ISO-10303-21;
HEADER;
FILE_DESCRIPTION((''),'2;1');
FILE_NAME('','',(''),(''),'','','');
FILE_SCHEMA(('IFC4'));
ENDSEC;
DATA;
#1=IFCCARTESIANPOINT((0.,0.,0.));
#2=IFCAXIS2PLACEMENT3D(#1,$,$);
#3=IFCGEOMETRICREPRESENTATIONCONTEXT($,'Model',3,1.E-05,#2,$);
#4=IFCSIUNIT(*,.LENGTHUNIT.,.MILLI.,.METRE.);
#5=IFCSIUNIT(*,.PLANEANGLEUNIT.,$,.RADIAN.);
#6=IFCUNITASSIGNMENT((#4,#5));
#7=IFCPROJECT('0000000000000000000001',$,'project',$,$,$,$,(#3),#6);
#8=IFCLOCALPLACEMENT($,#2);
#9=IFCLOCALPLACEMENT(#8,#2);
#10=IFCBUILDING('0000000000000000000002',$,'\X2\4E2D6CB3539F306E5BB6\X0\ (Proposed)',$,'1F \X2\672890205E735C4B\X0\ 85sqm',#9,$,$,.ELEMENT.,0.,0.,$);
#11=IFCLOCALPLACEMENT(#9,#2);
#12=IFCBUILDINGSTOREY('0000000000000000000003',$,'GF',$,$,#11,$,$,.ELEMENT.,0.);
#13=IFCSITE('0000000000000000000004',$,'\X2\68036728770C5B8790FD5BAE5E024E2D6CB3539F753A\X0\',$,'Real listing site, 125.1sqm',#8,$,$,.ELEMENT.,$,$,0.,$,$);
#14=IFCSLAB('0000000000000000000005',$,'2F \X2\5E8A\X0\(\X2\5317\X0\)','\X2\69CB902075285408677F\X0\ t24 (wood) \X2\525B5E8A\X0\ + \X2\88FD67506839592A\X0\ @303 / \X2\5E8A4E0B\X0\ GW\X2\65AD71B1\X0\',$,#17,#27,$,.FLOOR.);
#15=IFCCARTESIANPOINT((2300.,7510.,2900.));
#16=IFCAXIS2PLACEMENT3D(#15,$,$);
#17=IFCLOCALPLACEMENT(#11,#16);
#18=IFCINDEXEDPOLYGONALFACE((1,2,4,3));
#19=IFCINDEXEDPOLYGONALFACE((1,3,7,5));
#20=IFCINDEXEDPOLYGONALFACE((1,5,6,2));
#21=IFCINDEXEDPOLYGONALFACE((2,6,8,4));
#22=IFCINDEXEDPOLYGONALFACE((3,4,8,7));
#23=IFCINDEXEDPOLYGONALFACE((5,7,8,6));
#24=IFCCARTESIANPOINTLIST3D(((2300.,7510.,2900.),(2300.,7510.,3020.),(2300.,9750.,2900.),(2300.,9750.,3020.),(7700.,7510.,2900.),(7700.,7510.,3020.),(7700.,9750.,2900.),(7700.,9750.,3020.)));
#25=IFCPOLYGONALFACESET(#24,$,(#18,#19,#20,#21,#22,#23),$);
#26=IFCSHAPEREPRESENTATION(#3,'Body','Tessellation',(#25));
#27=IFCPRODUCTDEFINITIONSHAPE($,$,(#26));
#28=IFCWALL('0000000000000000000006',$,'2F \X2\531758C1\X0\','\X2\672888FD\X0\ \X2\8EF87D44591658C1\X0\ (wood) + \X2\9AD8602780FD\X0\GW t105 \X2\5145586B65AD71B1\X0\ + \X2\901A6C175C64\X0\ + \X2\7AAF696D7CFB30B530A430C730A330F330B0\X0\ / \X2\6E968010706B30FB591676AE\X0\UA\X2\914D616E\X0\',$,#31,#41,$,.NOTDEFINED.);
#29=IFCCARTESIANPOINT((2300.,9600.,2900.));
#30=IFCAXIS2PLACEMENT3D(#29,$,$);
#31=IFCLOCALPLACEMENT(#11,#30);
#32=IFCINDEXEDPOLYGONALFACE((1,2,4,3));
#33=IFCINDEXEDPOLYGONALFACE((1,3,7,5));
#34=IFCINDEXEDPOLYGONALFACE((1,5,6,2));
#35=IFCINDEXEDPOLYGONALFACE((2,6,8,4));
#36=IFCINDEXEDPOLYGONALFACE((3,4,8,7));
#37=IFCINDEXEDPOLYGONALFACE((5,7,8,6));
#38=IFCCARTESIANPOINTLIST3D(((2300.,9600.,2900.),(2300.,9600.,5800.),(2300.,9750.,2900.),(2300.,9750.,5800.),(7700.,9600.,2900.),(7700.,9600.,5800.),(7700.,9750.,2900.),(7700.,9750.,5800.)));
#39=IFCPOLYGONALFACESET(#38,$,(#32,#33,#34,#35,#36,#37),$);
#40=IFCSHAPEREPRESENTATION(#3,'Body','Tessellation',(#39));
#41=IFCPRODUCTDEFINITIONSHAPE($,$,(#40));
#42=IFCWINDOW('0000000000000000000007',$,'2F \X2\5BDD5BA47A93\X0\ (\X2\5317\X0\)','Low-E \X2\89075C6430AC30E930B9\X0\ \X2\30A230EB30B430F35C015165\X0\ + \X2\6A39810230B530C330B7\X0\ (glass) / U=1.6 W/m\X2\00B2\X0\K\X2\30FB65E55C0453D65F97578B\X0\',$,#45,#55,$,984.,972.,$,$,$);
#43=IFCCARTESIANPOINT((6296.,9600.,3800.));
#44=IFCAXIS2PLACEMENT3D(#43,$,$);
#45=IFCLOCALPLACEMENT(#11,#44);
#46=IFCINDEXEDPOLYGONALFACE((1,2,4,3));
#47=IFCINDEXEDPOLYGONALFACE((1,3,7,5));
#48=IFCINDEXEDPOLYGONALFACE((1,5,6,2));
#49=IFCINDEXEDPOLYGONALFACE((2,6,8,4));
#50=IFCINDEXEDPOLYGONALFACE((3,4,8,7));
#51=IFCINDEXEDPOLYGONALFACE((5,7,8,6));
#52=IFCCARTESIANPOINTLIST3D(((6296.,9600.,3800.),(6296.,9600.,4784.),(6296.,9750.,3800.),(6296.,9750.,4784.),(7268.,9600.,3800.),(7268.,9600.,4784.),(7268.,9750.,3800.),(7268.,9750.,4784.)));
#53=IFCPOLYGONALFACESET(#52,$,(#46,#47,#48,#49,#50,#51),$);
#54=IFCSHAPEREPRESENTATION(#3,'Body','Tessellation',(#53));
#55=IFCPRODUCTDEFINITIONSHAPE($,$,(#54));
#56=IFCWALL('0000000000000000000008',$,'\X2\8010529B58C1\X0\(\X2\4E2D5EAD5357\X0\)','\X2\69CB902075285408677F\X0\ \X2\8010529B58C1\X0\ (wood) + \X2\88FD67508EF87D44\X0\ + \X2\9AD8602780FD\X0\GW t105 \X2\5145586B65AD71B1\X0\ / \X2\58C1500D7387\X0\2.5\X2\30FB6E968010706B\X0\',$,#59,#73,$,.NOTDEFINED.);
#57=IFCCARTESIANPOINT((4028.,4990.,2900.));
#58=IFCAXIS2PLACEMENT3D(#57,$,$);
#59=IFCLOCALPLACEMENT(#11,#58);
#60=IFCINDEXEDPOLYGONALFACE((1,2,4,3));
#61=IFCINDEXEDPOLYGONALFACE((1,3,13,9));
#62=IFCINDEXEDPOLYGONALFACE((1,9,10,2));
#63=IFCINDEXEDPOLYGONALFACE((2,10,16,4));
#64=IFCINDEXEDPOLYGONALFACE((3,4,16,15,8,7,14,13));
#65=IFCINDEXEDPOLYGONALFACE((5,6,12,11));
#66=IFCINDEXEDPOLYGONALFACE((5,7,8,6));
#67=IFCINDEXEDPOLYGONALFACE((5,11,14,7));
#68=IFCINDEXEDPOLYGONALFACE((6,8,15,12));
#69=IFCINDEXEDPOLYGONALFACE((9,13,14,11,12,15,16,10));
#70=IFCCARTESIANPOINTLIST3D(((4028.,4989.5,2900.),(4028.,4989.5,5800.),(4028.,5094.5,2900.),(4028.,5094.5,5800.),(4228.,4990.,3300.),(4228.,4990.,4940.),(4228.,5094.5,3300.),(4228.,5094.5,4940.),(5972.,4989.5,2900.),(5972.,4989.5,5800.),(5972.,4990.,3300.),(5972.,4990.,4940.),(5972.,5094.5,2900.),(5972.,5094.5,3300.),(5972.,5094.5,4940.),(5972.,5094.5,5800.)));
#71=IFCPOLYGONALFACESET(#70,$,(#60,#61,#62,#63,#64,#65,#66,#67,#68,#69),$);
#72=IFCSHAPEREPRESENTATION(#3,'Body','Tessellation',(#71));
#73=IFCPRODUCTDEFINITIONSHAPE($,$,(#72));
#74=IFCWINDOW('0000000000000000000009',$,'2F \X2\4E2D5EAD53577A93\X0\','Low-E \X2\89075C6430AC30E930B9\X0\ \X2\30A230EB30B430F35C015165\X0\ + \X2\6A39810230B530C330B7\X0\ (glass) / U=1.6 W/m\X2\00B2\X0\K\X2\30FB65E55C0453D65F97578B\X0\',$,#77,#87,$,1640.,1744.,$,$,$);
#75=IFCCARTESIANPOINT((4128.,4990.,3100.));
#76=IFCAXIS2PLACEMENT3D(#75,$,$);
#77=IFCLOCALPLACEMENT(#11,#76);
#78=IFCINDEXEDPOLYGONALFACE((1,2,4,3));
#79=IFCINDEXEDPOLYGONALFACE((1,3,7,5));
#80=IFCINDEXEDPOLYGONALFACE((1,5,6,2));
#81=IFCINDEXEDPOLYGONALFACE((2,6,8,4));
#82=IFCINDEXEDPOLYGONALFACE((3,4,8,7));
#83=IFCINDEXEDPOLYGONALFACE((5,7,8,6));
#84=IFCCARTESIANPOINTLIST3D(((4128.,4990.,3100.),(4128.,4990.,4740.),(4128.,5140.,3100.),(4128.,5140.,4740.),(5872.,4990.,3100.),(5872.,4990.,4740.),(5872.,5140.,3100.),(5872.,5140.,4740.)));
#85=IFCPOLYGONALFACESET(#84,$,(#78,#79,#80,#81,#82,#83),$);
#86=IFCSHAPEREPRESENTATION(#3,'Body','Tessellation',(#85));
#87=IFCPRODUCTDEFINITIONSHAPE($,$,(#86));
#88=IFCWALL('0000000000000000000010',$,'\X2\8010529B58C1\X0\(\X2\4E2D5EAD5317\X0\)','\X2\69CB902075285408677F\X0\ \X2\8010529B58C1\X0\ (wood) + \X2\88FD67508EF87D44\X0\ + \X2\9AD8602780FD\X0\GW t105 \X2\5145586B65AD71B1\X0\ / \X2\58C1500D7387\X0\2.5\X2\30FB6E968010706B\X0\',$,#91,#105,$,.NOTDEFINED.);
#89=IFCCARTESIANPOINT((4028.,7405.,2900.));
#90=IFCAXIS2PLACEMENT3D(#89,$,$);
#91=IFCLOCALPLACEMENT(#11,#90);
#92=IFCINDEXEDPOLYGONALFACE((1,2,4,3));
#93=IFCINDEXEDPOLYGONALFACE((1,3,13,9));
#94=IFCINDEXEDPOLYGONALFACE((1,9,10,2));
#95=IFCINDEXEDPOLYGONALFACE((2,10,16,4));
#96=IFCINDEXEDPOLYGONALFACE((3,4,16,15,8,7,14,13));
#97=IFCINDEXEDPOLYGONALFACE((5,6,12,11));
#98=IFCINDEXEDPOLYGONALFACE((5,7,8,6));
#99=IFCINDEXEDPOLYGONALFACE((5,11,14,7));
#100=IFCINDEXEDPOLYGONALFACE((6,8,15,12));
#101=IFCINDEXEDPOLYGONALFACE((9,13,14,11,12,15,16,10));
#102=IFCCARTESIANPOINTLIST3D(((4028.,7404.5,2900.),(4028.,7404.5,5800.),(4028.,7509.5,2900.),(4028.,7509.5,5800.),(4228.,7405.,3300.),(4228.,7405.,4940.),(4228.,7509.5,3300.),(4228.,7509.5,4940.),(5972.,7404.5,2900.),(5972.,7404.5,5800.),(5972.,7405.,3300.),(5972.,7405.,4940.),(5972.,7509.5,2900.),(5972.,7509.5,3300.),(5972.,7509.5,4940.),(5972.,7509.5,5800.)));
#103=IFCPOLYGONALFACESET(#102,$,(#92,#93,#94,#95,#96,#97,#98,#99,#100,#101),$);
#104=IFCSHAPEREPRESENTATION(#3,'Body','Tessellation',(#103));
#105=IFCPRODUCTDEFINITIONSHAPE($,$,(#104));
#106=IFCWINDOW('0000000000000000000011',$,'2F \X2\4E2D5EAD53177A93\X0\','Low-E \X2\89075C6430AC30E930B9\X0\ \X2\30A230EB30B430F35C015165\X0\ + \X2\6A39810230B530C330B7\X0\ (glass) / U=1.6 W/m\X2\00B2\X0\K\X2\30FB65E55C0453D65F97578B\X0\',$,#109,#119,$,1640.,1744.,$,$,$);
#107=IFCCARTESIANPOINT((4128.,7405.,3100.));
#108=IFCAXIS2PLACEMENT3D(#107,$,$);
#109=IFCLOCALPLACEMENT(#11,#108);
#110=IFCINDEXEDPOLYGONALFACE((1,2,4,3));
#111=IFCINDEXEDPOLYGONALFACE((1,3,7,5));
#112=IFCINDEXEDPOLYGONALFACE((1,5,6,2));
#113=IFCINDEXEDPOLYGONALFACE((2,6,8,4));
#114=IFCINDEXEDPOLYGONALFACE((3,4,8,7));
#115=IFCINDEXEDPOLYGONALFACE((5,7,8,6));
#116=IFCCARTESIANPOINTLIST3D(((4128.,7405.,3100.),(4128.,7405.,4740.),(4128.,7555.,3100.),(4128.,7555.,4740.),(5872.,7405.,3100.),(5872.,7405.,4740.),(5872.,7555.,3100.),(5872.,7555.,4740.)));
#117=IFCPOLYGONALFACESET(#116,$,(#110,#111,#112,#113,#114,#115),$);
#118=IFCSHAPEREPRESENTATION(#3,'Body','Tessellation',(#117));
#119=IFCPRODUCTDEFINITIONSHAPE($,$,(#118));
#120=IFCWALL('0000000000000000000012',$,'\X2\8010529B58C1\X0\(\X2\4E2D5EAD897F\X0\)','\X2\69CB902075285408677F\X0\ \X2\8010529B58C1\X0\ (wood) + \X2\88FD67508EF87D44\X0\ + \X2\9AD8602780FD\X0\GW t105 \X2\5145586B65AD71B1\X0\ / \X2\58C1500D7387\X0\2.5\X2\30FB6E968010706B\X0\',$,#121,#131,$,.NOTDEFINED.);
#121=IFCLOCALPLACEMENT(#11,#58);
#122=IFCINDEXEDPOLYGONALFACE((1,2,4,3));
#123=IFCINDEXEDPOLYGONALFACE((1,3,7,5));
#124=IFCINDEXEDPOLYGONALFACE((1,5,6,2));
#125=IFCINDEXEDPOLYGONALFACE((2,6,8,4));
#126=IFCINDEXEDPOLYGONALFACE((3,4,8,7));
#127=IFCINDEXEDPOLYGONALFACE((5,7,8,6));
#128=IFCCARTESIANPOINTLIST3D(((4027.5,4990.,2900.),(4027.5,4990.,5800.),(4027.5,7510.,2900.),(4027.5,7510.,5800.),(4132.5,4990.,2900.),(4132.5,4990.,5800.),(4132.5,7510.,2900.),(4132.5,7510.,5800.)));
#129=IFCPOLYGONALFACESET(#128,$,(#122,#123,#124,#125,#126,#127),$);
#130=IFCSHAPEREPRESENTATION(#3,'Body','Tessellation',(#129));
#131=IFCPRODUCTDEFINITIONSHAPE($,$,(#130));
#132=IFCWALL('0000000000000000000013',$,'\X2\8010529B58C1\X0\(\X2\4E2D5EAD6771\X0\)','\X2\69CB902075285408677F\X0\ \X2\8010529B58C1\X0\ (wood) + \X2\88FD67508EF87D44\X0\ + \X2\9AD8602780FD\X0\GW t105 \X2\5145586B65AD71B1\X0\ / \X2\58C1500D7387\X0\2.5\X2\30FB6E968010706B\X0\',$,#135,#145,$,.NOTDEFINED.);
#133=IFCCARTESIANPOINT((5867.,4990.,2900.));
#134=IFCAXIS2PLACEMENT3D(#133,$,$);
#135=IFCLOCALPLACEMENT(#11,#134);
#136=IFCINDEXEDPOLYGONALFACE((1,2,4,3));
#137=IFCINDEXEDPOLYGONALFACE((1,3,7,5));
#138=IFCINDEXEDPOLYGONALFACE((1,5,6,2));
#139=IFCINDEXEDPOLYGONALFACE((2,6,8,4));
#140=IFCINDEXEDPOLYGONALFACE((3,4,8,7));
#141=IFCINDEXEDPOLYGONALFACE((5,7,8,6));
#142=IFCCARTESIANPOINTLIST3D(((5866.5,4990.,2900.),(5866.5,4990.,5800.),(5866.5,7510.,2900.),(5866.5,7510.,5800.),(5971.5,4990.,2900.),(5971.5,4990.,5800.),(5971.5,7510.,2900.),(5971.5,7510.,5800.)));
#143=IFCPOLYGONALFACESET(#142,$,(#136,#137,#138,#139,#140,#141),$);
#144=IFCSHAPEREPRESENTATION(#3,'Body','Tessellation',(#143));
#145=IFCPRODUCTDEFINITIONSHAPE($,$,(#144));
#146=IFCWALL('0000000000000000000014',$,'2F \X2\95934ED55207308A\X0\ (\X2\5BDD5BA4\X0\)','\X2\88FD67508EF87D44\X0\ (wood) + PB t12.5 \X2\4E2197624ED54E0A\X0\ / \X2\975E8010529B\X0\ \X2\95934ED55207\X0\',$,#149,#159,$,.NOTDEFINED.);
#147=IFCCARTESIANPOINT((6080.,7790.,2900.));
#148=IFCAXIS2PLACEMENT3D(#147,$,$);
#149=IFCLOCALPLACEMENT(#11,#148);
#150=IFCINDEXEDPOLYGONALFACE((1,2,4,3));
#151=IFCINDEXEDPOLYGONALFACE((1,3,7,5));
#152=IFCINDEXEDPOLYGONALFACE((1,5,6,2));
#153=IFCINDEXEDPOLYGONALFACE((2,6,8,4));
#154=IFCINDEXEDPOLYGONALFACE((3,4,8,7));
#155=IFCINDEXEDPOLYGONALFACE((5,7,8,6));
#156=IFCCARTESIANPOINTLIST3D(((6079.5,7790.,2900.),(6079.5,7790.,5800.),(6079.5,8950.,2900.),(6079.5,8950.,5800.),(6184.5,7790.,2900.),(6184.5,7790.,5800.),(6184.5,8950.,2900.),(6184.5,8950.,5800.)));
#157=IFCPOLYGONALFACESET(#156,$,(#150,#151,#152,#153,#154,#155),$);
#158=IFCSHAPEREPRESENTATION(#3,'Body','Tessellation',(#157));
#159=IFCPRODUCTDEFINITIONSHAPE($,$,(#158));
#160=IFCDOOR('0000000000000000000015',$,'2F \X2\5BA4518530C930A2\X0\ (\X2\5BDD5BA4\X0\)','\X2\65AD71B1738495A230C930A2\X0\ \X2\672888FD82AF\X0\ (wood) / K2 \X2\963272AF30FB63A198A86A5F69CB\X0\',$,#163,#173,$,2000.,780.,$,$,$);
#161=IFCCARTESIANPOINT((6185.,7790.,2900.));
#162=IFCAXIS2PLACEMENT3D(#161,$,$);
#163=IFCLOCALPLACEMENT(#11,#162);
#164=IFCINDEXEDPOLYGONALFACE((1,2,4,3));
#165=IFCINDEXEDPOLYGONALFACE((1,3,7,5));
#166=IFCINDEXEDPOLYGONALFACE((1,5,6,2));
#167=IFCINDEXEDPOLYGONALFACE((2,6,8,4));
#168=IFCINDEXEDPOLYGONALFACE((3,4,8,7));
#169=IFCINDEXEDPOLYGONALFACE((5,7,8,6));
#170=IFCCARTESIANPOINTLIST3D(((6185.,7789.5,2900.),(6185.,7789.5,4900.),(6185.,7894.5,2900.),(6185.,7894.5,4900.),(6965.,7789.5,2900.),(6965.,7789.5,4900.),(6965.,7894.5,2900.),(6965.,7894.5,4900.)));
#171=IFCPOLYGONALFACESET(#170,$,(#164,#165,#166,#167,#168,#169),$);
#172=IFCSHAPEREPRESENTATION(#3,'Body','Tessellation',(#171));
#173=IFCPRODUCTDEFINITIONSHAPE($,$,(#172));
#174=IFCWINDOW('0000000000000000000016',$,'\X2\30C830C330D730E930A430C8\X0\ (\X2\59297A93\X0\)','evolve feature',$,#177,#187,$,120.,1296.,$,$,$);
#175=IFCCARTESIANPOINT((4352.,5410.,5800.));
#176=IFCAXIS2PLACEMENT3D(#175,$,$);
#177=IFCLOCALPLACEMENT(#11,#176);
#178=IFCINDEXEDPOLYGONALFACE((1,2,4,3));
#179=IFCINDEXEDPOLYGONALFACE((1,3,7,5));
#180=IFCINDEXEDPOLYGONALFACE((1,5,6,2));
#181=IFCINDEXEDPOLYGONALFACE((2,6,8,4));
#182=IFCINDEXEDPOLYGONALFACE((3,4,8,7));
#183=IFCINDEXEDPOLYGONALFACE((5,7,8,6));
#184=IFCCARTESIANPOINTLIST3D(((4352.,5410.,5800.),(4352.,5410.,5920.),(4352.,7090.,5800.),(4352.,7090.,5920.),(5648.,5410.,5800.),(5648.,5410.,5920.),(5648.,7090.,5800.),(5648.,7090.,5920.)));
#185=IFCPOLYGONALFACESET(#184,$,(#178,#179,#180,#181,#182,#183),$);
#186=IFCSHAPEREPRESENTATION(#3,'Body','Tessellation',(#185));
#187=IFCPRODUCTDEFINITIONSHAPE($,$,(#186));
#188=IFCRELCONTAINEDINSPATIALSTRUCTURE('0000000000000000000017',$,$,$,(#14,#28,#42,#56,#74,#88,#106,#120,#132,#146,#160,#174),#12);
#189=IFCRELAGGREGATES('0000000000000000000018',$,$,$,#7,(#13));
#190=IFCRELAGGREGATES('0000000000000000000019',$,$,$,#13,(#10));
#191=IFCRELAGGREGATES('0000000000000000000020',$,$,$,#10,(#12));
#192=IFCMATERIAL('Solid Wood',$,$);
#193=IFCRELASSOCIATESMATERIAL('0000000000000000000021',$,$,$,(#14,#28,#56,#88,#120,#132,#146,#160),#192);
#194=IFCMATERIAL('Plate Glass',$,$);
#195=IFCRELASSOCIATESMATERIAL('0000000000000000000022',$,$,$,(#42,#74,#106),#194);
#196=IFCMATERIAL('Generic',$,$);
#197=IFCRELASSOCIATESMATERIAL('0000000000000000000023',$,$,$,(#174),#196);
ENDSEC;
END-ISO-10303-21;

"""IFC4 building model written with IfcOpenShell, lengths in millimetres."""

from ifc_helpers import new_model, si_unit, frame, frame_2d, origin, place, context, project, spatial, rectangle, extrude, material, element, fill, save


model = new_model("IFC4")

# Units and contexts
model_context = context("Model", 3, precision=1e-05, world=origin())
ifc_project = project(units=[si_unit("LENGTHUNIT", "METRE", prefix="MILLI"), si_unit("PLANEANGLEUNIT", "RADIAN")], contexts=[model_context])

# Site, building, storey
site_placement = place(None, origin())
site = spatial("IfcSite", under=ifc_project, at=site_placement, Name="栃木県宇都宮市中河原町", ObjectType="Real listing site, 125.1sqm", CompositionType="ELEMENT", RefElevation=0.0)
building_placement = place(site_placement, origin())
building = spatial("IfcBuilding", under=site, at=building_placement, Name="中河原の家 (Proposed)", ObjectType="1F 木造平屋 85sqm", CompositionType="ELEMENT", ElevationOfRefHeight=0.0, ElevationOfTerrain=0.0)
storey_placement = place(building_placement, origin())
storey = spatial("IfcBuildingStorey", under=building, at=storey_placement, Name="GF", CompositionType="ELEMENT", Elevation=0.0)

# Slab
ifc_material_1 = material(Name="Solid Wood")
slab_placement = place(storey_placement, frame((2300.0, 7510.0, 2900.0)))
element("IfcSlab", 1, at=slab_placement, inside=storey, material=ifc_material_1, Name="2F 床(北)", Description="構造用合板 t24 (wood) 剛床 + 製材根太 @303 / 床下 GW断熱", PredefinedType="FLOOR", context=model_context, shape_type="SweptSolid", body=[
    extrude(rectangle(XDim=5400.0, YDim=2240.0, at=frame_2d((2700.0, 1120.0))), frame((2300.0, 7510.0, 2900.0)), (0.0, 0.0, 1.0), 120.0),
])

# Walls, openings, windows
wall_1_placement = place(storey_placement, frame((2300.0, 9600.0, 2900.0)))
wall_1 = element("IfcWall", 2, at=wall_1_placement, inside=storey, material=ifc_material_1, Name="2F 北壁", Description="木製 軸組外壁 (wood) + 高性能GW t105 充填断熱 + 通気層 + 窯業系サイディング / 準耐火・外皮UA配慮", PredefinedType="NOTDEFINED", context=model_context, shape_type="SweptSolid", body=[
    extrude(rectangle(XDim=5400.0, YDim=150.0, at=frame_2d((2700.0, 75.0))), frame((2300.0, 9600.0, 2900.0)), (0.0, 0.0, 1.0), 2900.0),
])
opening_1_placement = place(storey_placement, frame((6296.0, 9600.0, 3800.0)))
opening_1 = element("IfcOpeningElement", 3, at=opening_1_placement, cuts=wall_1, PredefinedType="NOTDEFINED", context=model_context, shape_type="SweptSolid", body=[
    extrude(rectangle(XDim=972.0, YDim=150.0, at=frame_2d((486.0, 75.0))), frame((6296.0, 9600.0, 3800.0)), (0.0, 0.0, 1.0), 984.0),
])
ifc_material_2 = material(Name="Plate Glass")
window_1_placement = place(storey_placement, frame((6296.0, 9600.0, 3800.0)))
window_1 = element("IfcWindow", 4, at=window_1_placement, inside=storey, material=ifc_material_2, Name="2F 寝室窓 (北)", Description="Low-E 複層ガラス アルゴン封入 + 樹脂サッシ (glass) / U=1.6 W/m²K・日射取得型", OverallHeight=984.0, OverallWidth=972.0, context=model_context, shape_type="SweptSolid", body=[
    extrude(rectangle(XDim=972.0, YDim=150.0, at=frame_2d((486.0, 75.0))), frame((6296.0, 9600.0, 3800.0)), (0.0, 0.0, 1.0), 984.0),
])
fill(opening_1, window_1)
wall_2_placement = place(storey_placement, frame((4028.0, 4990.0, 2900.0)))
wall_2 = element("IfcWall", 5, at=wall_2_placement, inside=storey, material=ifc_material_1, Name="耐力壁(中庭南)", Description="構造用合板 耐力壁 (wood) + 製材軸組 + 高性能GW t105 充填断熱 / 壁倍率2.5・準耐火", PredefinedType="NOTDEFINED", context=model_context, shape_type="SweptSolid", body=[
    extrude(rectangle(XDim=1944.0, YDim=105.0, at=frame_2d((972.0, 52.0))), frame((4028.0, 4990.0, 2900.0)), (0.0, 0.0, 1.0), 2900.0),
])
opening_2_placement = place(storey_placement, frame((4128.0, 4990.0, 3100.0)))
opening_2 = element("IfcOpeningElement", 6, at=opening_2_placement, cuts=wall_2, PredefinedType="NOTDEFINED", context=model_context, shape_type="SweptSolid", body=[
    extrude(rectangle(XDim=1744.0, YDim=150.0, at=frame_2d((872.0, 75.0))), frame((4128.0, 4990.0, 3100.0)), (0.0, 0.0, 1.0), 1640.0),
])
window_2_placement = place(storey_placement, frame((4128.0, 4990.0, 3100.0)))
window_2 = element("IfcWindow", 7, at=window_2_placement, inside=storey, material=ifc_material_2, Name="2F 中庭南窓", Description="Low-E 複層ガラス アルゴン封入 + 樹脂サッシ (glass) / U=1.6 W/m²K・日射取得型", OverallHeight=1640.0, OverallWidth=1744.0, context=model_context, shape_type="SweptSolid", body=[
    extrude(rectangle(XDim=1744.0, YDim=150.0, at=frame_2d((872.0, 75.0))), frame((4128.0, 4990.0, 3100.0)), (0.0, 0.0, 1.0), 1640.0),
])
fill(opening_2, window_2)
wall_3_placement = place(storey_placement, frame((4028.0, 7405.0, 2900.0)))
wall_3 = element("IfcWall", 8, at=wall_3_placement, inside=storey, material=ifc_material_1, Name="耐力壁(中庭北)", Description="構造用合板 耐力壁 (wood) + 製材軸組 + 高性能GW t105 充填断熱 / 壁倍率2.5・準耐火", PredefinedType="NOTDEFINED", context=model_context, shape_type="SweptSolid", body=[
    extrude(rectangle(XDim=1944.0, YDim=105.0, at=frame_2d((972.0, 52.0))), frame((4028.0, 7405.0, 2900.0)), (0.0, 0.0, 1.0), 2900.0),
])
opening_3_placement = place(storey_placement, frame((4128.0, 7405.0, 3100.0)))
opening_3 = element("IfcOpeningElement", 9, at=opening_3_placement, cuts=wall_3, PredefinedType="NOTDEFINED", context=model_context, shape_type="SweptSolid", body=[
    extrude(rectangle(XDim=1744.0, YDim=150.0, at=frame_2d((872.0, 75.0))), frame((4128.0, 7405.0, 3100.0)), (0.0, 0.0, 1.0), 1640.0),
])
window_3_placement = place(storey_placement, frame((4128.0, 7405.0, 3100.0)))
window_3 = element("IfcWindow", 10, at=window_3_placement, inside=storey, material=ifc_material_2, Name="2F 中庭北窓", Description="Low-E 複層ガラス アルゴン封入 + 樹脂サッシ (glass) / U=1.6 W/m²K・日射取得型", OverallHeight=1640.0, OverallWidth=1744.0, context=model_context, shape_type="SweptSolid", body=[
    extrude(rectangle(XDim=1744.0, YDim=150.0, at=frame_2d((872.0, 75.0))), frame((4128.0, 7405.0, 3100.0)), (0.0, 0.0, 1.0), 1640.0),
])
fill(opening_3, window_3)

# Walls
wall_4_placement = place(storey_placement, frame((4028.0, 4990.0, 2900.0)))
element("IfcWall", 11, at=wall_4_placement, inside=storey, material=ifc_material_1, Name="耐力壁(中庭西)", Description="構造用合板 耐力壁 (wood) + 製材軸組 + 高性能GW t105 充填断熱 / 壁倍率2.5・準耐火", PredefinedType="NOTDEFINED", context=model_context, shape_type="SweptSolid", body=[
    extrude(rectangle(XDim=105.0, YDim=2520.0, at=frame_2d((52.0, 1260.0))), frame((4028.0, 4990.0, 2900.0)), (0.0, 0.0, 1.0), 2900.0),
])
wall_5_placement = place(storey_placement, frame((5867.0, 4990.0, 2900.0)))
element("IfcWall", 12, at=wall_5_placement, inside=storey, material=ifc_material_1, Name="耐力壁(中庭東)", Description="構造用合板 耐力壁 (wood) + 製材軸組 + 高性能GW t105 充填断熱 / 壁倍率2.5・準耐火", PredefinedType="NOTDEFINED", context=model_context, shape_type="SweptSolid", body=[
    extrude(rectangle(XDim=105.0, YDim=2520.0, at=frame_2d((52.0, 1260.0))), frame((5867.0, 4990.0, 2900.0)), (0.0, 0.0, 1.0), 2900.0),
])
wall_6_placement = place(storey_placement, frame((6080.0, 7790.0, 2900.0)))
element("IfcWall", 13, at=wall_6_placement, inside=storey, material=ifc_material_1, Name="2F 間仕切り (寝室)", Description="製材軸組 (wood) + PB t12.5 両面仕上 / 非耐力 間仕切", PredefinedType="NOTDEFINED", context=model_context, shape_type="SweptSolid", body=[
    extrude(rectangle(XDim=105.0, YDim=1160.0, at=frame_2d((52.0, 580.0))), frame((6080.0, 7790.0, 2900.0)), (0.0, 0.0, 1.0), 2900.0),
])

# Door
door_placement = place(storey_placement, frame((6185.0, 7790.0, 2900.0)))
element("IfcDoor", 14, at=door_placement, inside=storey, material=ifc_material_1, Name="2F 室内ドア (寝室)", Description="断熱玄関ドア 木製芯 (wood) / K2 防犯・採風機構", OverallHeight=2000.0, OverallWidth=780.0, context=model_context, shape_type="SweptSolid", body=[
    extrude(rectangle(XDim=780.0, YDim=105.0, at=frame_2d((390.0, 52.0))), frame((6185.0, 7790.0, 2900.0)), (0.0, 0.0, 1.0), 2000.0),
])

# Window
ifc_material_3 = material(Name="Generic")
window_4_placement = place(storey_placement, frame((4352.0, 5410.0, 5800.0)))
element("IfcWindow", 15, at=window_4_placement, inside=storey, material=ifc_material_3, Name="トップライト (天窓)", Description="evolve feature", OverallHeight=120.0, OverallWidth=1296.0, context=model_context, shape_type="SweptSolid", body=[
    extrude(rectangle(XDim=1296.0, YDim=1680.0, at=frame_2d((648.0, 840.0))), frame((4352.0, 5410.0, 5800.0)), (0.0, 0.0, 1.0), 120.0),
])

save(model, "model.ifc")
